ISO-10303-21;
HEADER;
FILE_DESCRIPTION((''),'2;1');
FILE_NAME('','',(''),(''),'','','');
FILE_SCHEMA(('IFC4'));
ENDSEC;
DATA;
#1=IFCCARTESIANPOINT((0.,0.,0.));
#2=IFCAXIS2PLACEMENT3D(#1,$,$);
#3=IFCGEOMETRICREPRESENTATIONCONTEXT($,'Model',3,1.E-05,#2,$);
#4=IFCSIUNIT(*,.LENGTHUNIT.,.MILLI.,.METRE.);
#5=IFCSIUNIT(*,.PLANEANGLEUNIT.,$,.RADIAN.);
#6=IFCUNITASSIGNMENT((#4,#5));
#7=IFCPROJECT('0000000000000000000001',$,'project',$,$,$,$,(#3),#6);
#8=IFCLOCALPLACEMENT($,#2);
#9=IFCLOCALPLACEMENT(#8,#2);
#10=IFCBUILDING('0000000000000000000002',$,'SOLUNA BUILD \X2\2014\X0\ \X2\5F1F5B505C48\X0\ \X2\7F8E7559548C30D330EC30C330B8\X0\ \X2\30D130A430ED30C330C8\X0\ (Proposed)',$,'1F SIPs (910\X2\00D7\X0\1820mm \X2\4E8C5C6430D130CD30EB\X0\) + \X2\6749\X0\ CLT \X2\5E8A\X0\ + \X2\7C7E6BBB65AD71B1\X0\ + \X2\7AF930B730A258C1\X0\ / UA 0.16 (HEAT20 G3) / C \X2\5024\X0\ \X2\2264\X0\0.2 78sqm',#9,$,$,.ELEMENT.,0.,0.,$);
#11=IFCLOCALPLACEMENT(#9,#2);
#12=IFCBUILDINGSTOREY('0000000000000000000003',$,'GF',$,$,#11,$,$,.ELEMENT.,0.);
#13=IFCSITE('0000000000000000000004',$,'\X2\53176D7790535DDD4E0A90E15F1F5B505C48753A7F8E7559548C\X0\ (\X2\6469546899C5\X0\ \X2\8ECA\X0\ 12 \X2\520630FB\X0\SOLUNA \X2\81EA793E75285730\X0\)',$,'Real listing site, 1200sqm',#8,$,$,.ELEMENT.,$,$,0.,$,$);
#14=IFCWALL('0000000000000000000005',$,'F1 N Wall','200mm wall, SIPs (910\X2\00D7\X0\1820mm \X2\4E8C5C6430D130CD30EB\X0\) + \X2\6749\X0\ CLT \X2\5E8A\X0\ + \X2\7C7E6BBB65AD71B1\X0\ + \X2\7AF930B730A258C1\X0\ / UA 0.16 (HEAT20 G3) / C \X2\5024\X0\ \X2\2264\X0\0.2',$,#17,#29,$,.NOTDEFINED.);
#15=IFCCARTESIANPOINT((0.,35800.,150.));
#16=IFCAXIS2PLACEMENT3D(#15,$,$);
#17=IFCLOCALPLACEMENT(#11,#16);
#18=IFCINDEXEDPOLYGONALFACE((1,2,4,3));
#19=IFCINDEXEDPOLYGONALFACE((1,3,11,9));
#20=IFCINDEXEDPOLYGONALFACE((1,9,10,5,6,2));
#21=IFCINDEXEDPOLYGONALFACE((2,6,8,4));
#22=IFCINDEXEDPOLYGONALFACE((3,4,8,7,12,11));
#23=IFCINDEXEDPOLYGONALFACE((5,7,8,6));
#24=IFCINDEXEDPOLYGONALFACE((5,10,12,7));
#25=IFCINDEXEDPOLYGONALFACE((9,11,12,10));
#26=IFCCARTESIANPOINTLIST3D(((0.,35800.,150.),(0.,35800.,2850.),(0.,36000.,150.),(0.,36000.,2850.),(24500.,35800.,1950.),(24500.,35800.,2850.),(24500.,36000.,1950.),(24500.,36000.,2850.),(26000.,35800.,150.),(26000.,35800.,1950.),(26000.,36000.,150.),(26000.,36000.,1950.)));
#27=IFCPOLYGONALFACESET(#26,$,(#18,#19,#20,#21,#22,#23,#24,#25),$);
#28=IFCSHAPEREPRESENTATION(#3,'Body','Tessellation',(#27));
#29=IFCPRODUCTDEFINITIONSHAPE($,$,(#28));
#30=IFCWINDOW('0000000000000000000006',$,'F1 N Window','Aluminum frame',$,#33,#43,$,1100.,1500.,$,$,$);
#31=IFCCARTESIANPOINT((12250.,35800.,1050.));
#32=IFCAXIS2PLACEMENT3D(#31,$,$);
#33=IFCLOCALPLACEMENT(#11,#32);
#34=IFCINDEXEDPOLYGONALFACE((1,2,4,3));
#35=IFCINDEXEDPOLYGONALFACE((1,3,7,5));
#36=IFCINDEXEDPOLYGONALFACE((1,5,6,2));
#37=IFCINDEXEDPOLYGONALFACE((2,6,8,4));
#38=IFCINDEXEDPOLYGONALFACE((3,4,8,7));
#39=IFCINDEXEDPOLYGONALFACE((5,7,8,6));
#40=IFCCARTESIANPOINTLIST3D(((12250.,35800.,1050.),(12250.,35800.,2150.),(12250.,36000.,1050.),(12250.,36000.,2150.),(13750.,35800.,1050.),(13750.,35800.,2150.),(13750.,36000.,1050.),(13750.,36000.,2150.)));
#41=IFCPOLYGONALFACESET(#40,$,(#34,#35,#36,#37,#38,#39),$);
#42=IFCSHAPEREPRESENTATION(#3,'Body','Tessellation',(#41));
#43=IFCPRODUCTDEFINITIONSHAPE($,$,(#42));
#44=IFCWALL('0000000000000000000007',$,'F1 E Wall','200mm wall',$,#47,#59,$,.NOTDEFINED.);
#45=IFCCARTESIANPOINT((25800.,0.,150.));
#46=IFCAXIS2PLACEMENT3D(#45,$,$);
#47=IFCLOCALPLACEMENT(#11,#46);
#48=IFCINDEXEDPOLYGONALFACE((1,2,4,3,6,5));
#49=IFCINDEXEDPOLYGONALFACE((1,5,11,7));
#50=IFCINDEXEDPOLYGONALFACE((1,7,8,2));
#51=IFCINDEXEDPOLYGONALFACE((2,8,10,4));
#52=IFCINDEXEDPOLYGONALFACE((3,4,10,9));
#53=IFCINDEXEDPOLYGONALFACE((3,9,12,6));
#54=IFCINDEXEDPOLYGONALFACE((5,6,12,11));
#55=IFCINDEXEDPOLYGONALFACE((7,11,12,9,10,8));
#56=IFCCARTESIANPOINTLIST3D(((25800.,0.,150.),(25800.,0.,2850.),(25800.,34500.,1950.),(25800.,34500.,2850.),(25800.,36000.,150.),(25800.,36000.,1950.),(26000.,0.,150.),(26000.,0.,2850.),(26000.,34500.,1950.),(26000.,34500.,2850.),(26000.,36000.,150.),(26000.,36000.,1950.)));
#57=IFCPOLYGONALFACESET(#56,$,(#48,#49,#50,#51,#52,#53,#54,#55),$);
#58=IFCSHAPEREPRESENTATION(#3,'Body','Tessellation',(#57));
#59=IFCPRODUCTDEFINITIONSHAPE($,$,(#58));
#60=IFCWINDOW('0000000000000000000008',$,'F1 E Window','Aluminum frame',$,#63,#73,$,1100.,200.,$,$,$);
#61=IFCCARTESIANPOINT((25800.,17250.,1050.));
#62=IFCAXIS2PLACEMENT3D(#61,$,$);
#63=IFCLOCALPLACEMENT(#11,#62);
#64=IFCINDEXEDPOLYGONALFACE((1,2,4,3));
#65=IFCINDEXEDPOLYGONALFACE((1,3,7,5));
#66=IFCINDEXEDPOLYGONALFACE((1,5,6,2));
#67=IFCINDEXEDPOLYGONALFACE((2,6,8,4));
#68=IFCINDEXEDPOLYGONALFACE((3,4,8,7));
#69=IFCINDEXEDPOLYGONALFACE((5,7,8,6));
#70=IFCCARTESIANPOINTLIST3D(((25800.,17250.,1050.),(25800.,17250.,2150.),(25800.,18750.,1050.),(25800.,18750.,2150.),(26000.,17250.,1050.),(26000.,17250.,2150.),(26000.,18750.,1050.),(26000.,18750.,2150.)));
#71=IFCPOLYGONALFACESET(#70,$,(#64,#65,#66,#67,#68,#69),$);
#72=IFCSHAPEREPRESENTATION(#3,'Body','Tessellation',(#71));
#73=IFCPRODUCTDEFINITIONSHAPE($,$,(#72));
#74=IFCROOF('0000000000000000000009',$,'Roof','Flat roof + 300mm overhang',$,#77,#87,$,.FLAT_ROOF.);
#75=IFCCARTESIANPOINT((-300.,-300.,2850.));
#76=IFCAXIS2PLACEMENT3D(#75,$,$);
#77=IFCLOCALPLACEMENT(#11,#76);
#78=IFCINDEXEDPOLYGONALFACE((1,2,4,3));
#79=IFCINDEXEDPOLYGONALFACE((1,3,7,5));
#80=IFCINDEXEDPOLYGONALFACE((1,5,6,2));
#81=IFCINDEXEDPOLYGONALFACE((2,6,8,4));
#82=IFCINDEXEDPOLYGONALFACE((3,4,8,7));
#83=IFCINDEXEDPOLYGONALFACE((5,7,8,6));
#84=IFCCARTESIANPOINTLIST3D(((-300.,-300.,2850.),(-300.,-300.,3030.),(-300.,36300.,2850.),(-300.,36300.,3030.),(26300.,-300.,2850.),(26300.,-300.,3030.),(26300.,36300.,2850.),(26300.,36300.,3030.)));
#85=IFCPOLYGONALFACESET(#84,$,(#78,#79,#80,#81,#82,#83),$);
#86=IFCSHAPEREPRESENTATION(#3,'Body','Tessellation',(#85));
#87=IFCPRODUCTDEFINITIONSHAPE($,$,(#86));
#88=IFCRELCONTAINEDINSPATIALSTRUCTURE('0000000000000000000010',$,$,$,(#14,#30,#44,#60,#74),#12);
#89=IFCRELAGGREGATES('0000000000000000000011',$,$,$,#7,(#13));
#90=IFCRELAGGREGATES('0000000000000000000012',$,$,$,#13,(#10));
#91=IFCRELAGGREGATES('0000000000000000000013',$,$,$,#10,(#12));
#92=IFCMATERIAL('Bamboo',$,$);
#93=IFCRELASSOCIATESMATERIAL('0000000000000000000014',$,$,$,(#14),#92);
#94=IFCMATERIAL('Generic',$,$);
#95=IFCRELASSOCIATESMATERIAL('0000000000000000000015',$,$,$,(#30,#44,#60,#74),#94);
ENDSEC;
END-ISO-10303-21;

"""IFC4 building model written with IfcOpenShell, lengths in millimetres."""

from ifc_helpers import new_model, si_unit, frame, frame_2d, origin, place, context, project, spatial, rectangle, extrude, material, element, fill, save


model = new_model("IFC4")

# Units and contexts
model_context = context("Model", 3, precision=1e-05, world=origin())
ifc_project = project(units=[si_unit("LENGTHUNIT", "METRE", prefix="MILLI"), si_unit("PLANEANGLEUNIT", "RADIAN")], contexts=[model_context])

# Site, building, storey
site_placement = place(None, origin())
site = spatial("IfcSite", under=ifc_project, at=site_placement, Name="北海道川上郡弟子屈町美留和 (摩周駅 車 12 分・SOLUNA 自社用地)", ObjectType="Real listing site, 1200sqm", CompositionType="ELEMENT", RefElevation=0.0)
building_placement = place(site_placement, origin())
building = spatial("IfcBuilding", under=site, at=building_placement, Name="SOLUNA BUILD — 弟子屈 美留和ビレッジ パイロット (Proposed)", ObjectType="1F SIPs (910×1820mm 二層パネル) + 杉 CLT 床 + 籾殻断熱 + 竹シア壁 / UA 0.16 (HEAT20 G3) / C 値 ≤0.2 78sqm", CompositionType="ELEMENT", ElevationOfRefHeight=0.0, ElevationOfTerrain=0.0)
storey_placement = place(building_placement, origin())
storey = spatial("IfcBuildingStorey", under=building, at=storey_placement, Name="GF", CompositionType="ELEMENT", Elevation=0.0)

# Wall, opening, window
ifc_material_1 = material(Name="Bamboo")
wall_1_placement = place(storey_placement, frame((0.0, 35800.0, 150.0)))
wall_1 = element("IfcWall", 1, at=wall_1_placement, inside=storey, material=ifc_material_1, Name="F1 N Wall", Description="200mm wall, SIPs (910×1820mm 二層パネル) + 杉 CLT 床 + 籾殻断熱 + 竹シア壁 / UA 0.16 (HEAT20 G3) / C 値 ≤0.2", PredefinedType="NOTDEFINED", context=model_context, shape_type="SweptSolid", body=[
    extrude(rectangle(XDim=26000.0, YDim=200.0, at=frame_2d((13000.0, 100.0))), frame((0.0, 35800.0, 150.0)), (0.0, 0.0, 1.0), 2700.0),
])
opening_1_placement = place(storey_placement, frame((12250.0, 35800.0, 1050.0)))
opening_1 = element("IfcOpeningElement", 2, at=opening_1_placement, cuts=wall_1, PredefinedType="NOTDEFINED", context=model_context, shape_type="SweptSolid", body=[
    extrude(rectangle(XDim=1500.0, YDim=200.0, at=frame_2d((750.0, 100.0))), frame((12250.0, 35800.0, 1050.0)), (0.0, 0.0, 1.0), 1100.0),
])
ifc_material_2 = material(Name="Generic")
window_1_placement = place(storey_placement, frame((12250.0, 35800.0, 1050.0)))
window_1 = element("IfcWindow", 3, at=window_1_placement, inside=storey, material=ifc_material_2, Name="F1 N Window", Description="Aluminum frame", OverallHeight=1100.0, OverallWidth=1500.0, context=model_context, shape_type="SweptSolid", body=[
    extrude(rectangle(XDim=1500.0, YDim=200.0, at=frame_2d((750.0, 100.0))), frame((12250.0, 35800.0, 1050.0)), (0.0, 0.0, 1.0), 1100.0),
])
fill(opening_1, window_1)

# Wall, opening, window
wall_2_placement = place(storey_placement, frame((25800.0, 0.0, 150.0)))
wall_2 = element("IfcWall", 4, at=wall_2_placement, inside=storey, material=ifc_material_2, Name="F1 E Wall", Description="200mm wall", PredefinedType="NOTDEFINED", context=model_context, shape_type="SweptSolid", body=[
    extrude(rectangle(XDim=200.0, YDim=36000.0, at=frame_2d((100.0, 18000.0))), frame((25800.0, 0.0, 150.0)), (0.0, 0.0, 1.0), 2700.0),
])
opening_2_placement = place(storey_placement, frame((25800.0, 17250.0, 1050.0)))
opening_2 = element("IfcOpeningElement", 5, at=opening_2_placement, cuts=wall_2, PredefinedType="NOTDEFINED", context=model_context, shape_type="SweptSolid", body=[
    extrude(rectangle(XDim=200.0, YDim=1500.0, at=frame_2d((100.0, 750.0))), frame((25800.0, 17250.0, 1050.0)), (0.0, 0.0, 1.0), 1100.0),
])
window_2_placement = place(storey_placement, frame((25800.0, 17250.0, 1050.0)))
window_2 = element("IfcWindow", 6, at=window_2_placement, inside=storey, material=ifc_material_2, Name="F1 E Window", Description="Aluminum frame", OverallHeight=1100.0, OverallWidth=200.0, context=model_context, shape_type="SweptSolid", body=[
    extrude(rectangle(XDim=200.0, YDim=1500.0, at=frame_2d((100.0, 750.0))), frame((25800.0, 17250.0, 1050.0)), (0.0, 0.0, 1.0), 1100.0),
])
fill(opening_2, window_2)

# Roof
roof_placement = place(storey_placement, frame((-300.0, -300.0, 2850.0)))
element("IfcRoof", 7, at=roof_placement, inside=storey, material=ifc_material_2, Name="Roof", Description="Flat roof + 300mm overhang", PredefinedType="FLAT_ROOF", context=model_context, shape_type="SweptSolid", body=[
    extrude(rectangle(XDim=26600.0, YDim=36600.0, at=frame_2d((13300.0, 18300.0))), frame((-300.0, -300.0, 2850.0)), (0.0, 0.0, 1.0), 180.0),
])

save(model, "model.ifc")
